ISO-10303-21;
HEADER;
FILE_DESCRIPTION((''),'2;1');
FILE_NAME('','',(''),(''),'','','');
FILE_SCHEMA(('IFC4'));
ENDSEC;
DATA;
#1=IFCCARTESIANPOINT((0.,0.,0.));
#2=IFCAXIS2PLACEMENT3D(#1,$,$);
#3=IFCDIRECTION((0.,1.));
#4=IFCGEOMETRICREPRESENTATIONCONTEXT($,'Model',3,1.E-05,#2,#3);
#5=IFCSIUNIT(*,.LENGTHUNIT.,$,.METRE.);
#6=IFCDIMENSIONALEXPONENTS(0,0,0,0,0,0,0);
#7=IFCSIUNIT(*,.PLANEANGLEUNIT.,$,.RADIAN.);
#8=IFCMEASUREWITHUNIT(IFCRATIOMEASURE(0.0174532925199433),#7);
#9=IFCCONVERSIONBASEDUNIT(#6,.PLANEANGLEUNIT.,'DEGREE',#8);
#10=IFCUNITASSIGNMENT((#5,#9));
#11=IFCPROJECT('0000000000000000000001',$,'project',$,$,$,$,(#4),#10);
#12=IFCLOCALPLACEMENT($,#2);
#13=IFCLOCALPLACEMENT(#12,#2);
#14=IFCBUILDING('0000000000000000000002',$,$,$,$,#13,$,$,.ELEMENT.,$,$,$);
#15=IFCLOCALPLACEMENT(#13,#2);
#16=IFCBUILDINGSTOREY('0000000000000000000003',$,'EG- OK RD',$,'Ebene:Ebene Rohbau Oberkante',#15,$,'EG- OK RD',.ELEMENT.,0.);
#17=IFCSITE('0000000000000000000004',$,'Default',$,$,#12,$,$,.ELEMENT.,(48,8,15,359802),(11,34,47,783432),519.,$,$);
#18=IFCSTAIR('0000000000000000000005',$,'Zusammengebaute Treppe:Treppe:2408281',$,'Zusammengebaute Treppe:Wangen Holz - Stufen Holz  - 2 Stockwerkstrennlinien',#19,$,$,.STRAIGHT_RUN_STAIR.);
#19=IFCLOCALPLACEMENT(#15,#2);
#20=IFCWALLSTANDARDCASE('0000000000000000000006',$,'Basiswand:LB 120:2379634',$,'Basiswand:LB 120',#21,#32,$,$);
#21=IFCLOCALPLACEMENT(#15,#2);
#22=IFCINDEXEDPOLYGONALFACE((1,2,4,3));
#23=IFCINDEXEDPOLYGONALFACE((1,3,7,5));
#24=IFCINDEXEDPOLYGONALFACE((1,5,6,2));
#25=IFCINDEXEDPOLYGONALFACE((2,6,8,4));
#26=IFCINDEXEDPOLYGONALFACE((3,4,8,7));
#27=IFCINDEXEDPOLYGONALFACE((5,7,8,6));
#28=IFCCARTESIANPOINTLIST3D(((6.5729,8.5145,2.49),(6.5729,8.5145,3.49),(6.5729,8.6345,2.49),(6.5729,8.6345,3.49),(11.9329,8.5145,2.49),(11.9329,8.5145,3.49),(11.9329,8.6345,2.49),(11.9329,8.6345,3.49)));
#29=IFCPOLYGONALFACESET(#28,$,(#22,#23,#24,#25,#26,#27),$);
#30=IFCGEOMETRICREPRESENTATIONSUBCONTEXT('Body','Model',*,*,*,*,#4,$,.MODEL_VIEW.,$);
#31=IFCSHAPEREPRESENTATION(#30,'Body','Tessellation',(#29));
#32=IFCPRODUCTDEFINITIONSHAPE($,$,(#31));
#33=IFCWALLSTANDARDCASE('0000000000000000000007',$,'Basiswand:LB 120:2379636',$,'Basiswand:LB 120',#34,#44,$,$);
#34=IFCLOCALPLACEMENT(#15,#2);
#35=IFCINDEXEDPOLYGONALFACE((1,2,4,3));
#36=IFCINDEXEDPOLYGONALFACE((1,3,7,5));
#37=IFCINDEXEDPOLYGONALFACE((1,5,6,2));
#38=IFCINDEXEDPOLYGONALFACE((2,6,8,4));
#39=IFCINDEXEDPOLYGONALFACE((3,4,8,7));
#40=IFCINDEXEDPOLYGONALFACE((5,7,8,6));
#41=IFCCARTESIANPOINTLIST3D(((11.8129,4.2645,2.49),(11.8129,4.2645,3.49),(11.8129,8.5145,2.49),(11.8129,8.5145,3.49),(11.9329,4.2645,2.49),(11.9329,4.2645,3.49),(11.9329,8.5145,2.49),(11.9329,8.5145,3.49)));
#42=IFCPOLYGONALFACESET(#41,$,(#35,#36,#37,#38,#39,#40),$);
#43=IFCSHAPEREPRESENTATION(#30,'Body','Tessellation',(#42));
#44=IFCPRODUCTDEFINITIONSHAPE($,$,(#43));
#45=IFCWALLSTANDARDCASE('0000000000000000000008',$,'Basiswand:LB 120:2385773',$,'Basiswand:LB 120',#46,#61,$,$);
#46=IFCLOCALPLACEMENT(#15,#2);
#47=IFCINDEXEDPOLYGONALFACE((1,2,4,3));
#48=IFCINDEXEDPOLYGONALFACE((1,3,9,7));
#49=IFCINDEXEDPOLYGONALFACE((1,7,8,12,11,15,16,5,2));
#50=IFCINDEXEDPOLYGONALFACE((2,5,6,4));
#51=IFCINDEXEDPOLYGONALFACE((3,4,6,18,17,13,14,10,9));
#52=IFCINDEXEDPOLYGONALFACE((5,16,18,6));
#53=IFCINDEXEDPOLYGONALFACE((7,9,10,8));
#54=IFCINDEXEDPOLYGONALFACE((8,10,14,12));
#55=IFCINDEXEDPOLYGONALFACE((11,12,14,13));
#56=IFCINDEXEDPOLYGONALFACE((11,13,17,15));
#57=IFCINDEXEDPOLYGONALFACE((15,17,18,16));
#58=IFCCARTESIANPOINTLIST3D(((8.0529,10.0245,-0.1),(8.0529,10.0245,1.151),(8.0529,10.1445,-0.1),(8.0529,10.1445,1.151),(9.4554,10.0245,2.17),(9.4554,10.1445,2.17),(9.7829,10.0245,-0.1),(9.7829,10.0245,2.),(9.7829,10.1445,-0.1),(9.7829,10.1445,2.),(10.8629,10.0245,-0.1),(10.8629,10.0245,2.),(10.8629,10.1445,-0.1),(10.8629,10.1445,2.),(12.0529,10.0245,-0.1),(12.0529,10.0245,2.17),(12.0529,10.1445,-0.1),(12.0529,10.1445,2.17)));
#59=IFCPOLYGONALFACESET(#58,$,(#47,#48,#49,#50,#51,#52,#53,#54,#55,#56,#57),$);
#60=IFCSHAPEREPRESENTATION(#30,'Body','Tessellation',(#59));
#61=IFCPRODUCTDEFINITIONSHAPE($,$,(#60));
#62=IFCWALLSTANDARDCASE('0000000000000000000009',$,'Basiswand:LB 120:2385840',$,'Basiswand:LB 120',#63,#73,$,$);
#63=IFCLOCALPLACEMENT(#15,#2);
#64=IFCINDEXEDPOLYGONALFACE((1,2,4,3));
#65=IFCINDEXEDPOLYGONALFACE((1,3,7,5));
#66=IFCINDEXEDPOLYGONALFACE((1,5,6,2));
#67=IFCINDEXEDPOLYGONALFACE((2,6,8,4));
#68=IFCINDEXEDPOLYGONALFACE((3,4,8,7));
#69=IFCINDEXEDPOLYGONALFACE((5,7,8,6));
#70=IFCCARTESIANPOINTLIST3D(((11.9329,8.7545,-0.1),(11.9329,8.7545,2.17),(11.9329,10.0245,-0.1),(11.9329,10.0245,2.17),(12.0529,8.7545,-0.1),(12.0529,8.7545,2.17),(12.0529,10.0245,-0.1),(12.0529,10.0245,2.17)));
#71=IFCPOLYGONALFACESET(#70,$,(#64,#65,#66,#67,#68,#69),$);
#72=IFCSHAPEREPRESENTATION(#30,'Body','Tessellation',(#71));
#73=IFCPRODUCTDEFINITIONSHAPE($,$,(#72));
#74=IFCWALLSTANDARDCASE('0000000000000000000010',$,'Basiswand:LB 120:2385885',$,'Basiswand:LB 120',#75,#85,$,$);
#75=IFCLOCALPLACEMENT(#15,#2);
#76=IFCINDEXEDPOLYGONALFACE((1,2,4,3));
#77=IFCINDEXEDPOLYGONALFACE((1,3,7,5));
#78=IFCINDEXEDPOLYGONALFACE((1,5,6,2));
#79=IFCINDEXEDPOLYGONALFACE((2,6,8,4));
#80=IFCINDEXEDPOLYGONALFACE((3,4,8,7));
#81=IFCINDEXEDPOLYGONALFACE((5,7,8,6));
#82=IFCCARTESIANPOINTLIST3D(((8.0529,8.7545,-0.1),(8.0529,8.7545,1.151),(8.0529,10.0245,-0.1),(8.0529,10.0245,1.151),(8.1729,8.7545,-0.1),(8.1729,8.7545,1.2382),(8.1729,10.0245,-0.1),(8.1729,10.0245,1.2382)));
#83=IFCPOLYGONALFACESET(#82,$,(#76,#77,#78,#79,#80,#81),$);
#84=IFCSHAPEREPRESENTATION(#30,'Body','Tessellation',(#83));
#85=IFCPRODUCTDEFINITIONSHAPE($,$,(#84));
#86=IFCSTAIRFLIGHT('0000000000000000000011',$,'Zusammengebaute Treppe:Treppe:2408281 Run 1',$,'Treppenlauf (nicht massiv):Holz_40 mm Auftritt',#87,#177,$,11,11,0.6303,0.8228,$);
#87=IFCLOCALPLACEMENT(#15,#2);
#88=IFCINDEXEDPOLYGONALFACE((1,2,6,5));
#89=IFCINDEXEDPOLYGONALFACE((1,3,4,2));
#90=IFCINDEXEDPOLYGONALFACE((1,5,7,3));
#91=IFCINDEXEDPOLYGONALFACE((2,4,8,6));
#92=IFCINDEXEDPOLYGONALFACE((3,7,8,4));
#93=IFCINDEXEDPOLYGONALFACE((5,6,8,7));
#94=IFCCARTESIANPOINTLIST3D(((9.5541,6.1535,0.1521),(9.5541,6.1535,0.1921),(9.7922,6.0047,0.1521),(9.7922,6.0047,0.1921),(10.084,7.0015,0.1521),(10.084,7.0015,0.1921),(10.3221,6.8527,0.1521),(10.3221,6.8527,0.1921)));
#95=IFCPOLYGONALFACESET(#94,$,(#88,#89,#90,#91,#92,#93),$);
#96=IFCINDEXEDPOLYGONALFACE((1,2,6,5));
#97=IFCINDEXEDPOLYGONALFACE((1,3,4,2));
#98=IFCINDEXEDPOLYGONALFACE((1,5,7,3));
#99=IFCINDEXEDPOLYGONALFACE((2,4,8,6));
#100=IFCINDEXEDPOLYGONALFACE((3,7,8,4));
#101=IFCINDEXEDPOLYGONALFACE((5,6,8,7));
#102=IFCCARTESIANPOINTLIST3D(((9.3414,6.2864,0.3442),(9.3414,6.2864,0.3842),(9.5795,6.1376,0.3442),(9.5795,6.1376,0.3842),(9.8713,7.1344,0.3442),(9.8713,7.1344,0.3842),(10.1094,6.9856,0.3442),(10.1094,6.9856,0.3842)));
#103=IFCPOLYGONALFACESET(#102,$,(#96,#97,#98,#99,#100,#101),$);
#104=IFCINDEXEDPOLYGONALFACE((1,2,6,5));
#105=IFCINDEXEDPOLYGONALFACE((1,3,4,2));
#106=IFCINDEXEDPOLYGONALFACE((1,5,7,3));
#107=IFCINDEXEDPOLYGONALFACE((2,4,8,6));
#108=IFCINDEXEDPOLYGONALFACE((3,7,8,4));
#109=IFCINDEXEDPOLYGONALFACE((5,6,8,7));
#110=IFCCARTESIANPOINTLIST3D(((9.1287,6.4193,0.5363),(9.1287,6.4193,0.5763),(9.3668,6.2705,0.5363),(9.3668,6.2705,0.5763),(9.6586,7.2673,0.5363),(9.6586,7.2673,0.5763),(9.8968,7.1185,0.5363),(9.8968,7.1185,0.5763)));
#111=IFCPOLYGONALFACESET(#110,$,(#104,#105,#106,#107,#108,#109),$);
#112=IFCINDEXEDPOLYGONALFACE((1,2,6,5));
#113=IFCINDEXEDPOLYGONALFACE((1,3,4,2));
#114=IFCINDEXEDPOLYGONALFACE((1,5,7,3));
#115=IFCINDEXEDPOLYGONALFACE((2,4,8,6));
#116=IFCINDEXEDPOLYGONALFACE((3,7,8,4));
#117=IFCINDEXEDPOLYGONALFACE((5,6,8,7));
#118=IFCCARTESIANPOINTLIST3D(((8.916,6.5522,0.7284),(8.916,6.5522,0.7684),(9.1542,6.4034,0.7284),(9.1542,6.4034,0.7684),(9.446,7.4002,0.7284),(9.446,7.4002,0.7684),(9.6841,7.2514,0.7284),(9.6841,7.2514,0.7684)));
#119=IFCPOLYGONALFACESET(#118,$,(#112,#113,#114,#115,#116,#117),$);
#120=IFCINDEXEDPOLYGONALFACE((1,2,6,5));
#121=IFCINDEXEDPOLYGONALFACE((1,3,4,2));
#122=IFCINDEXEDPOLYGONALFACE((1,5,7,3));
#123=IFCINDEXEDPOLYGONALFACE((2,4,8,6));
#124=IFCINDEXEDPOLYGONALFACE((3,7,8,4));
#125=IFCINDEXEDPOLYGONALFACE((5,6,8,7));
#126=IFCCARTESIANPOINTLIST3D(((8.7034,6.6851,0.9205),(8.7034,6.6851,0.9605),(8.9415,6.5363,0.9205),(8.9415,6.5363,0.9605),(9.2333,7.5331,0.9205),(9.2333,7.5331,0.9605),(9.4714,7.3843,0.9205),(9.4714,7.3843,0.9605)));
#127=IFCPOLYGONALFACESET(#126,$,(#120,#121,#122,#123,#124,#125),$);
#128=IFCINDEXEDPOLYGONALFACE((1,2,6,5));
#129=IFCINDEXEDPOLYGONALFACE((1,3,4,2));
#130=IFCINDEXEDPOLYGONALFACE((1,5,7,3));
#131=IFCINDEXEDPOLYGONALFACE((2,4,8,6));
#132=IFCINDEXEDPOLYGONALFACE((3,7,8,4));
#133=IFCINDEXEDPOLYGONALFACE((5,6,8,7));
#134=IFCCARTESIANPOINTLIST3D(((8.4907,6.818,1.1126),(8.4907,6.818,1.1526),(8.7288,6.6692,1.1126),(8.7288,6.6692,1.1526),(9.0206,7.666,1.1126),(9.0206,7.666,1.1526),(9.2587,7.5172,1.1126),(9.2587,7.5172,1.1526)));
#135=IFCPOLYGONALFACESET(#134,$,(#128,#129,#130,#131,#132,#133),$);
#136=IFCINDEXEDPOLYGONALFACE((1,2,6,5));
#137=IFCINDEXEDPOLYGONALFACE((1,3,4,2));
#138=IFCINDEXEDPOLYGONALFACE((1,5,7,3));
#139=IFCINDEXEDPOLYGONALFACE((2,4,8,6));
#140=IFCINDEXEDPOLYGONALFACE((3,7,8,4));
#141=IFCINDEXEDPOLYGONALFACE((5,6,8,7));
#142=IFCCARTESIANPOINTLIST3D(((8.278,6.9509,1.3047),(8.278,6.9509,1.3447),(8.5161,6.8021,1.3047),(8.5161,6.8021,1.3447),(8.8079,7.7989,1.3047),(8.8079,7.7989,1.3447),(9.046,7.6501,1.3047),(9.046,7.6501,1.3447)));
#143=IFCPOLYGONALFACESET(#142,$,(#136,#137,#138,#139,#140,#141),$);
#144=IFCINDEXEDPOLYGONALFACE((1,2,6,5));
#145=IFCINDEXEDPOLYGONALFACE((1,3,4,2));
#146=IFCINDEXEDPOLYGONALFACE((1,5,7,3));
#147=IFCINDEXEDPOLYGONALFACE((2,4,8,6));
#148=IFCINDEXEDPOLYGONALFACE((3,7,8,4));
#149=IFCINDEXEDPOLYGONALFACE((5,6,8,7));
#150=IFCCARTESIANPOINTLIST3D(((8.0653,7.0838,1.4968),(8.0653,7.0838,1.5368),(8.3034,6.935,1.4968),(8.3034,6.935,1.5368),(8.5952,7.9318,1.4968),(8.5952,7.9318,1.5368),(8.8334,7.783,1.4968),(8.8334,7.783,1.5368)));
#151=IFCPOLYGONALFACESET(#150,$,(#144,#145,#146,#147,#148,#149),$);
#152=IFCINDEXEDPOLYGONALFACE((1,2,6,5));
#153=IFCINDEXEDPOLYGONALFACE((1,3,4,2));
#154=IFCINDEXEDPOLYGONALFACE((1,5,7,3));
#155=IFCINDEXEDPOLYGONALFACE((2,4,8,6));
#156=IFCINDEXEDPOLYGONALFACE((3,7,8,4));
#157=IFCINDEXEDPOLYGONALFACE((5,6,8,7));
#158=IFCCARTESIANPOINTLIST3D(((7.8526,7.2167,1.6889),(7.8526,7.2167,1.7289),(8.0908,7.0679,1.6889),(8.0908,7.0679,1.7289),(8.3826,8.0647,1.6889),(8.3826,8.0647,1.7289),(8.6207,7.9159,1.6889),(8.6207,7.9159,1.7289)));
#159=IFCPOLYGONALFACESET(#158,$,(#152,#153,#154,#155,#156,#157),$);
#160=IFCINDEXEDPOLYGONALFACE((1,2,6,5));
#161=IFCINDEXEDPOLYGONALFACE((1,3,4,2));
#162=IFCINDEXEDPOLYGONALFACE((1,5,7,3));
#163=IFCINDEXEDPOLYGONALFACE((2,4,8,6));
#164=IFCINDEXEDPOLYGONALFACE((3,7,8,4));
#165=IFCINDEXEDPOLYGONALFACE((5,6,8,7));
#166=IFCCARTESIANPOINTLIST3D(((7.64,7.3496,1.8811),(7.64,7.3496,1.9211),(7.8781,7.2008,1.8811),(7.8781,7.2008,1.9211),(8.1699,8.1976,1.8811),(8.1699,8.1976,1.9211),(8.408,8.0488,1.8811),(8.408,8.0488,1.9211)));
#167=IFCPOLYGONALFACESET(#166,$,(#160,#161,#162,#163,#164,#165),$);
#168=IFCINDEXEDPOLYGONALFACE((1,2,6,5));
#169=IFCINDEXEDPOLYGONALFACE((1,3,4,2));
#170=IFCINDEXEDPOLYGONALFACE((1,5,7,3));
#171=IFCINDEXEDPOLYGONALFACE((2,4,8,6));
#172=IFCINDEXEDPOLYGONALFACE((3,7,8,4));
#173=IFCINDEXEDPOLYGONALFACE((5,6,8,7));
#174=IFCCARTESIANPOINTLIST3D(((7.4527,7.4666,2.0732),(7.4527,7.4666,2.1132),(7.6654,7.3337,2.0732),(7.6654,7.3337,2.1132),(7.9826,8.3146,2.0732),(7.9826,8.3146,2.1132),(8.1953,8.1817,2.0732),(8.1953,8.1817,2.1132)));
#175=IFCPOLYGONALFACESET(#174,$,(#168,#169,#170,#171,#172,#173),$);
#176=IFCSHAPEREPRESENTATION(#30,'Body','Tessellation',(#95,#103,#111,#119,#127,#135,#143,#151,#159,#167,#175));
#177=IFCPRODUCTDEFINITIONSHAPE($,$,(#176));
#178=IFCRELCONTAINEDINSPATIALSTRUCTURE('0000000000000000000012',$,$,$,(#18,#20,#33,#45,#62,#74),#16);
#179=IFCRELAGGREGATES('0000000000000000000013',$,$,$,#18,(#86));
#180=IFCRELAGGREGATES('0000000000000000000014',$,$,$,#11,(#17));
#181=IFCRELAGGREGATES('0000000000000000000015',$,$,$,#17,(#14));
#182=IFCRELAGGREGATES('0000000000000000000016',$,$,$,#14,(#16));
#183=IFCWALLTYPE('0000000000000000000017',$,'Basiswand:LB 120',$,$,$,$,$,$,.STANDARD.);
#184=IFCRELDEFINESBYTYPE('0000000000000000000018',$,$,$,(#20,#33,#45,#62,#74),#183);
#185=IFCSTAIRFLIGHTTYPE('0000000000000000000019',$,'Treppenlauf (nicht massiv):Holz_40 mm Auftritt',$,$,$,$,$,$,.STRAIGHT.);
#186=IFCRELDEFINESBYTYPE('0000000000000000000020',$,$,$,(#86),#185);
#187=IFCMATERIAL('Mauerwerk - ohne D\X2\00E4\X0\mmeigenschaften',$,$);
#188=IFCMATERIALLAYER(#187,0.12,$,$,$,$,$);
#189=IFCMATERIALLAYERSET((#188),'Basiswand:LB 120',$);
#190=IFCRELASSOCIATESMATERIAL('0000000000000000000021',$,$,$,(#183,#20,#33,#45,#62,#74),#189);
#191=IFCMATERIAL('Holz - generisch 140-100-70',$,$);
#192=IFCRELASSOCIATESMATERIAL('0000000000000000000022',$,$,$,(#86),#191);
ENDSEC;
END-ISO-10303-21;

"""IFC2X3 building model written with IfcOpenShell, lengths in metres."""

from ifc_helpers import new_model, entity, si_unit, converted_unit, direction, frame, frame_2d, origin, place, context, subcontext, project, spatial, polyline, rectangle, extrude, clip, bounded_halfspace, material, layer, layer_set, layer_usage, type_object, element, aggregate, save


model = new_model("IFC2X3")

# Units and contexts
model_context = context("Model", 3, precision=1e-05, world=origin(), true_north=direction((0.0, 1.0)))
body_context = subcontext(model_context, "Body", "Model", "MODEL_VIEW")
ifc_project = project(units=[si_unit("LENGTHUNIT", "METRE"), converted_unit("PLANEANGLEUNIT", "DEGREE", entity("IfcRatioMeasure", 0.0174532925199433), si_unit("PLANEANGLEUNIT", "RADIAN"), dimensions=[0, 0, 0, 0, 0, 0, 0])], contexts=[model_context])

# Site, building, storey
site_placement = place(None, origin())
site = spatial("IfcSite", under=ifc_project, at=site_placement, Name="Default", CompositionType="ELEMENT", RefLatitude=(48, 8, 15, 359802), RefLongitude=(11, 34, 47, 783432), RefElevation=519.0)
building_placement = place(site_placement, origin())
building = spatial("IfcBuilding", under=site, at=building_placement, CompositionType="ELEMENT")
storey_placement = place(building_placement, origin())
storey = spatial("IfcBuildingStorey", under=building, at=storey_placement, Name="EG- OK RD", ObjectType="Ebene:Ebene Rohbau Oberkante", LongName="EG- OK RD", CompositionType="ELEMENT", Elevation=0.0)

# Stair
stair_placement = place(storey_placement, origin())
stair = element("IfcStair", 1, at=stair_placement, inside=storey, Name="Zusammengebaute Treppe:Treppe:2408281", ObjectType="Zusammengebaute Treppe:Wangen Holz - Stufen Holz  - 2 Stockwerkstrennlinien", ShapeType="STRAIGHT_RUN_STAIR")
ifc_material_1 = material(Name="Holz - generisch 140-100-70")

# Walls
ifc_material_2 = material(Name="Mauerwerk - ohne Dämmeigenschaften")
ifc_layer_1 = layer(ifc_material_2, 0.12)
ifc_layer_set_1 = layer_set([ifc_layer_1], Name="Basiswand:LB 120")
wall_type_1 = type_object("IfcWallType", Name="Basiswand:LB 120", PredefinedType="STANDARD", material=ifc_layer_set_1)
ifc_layer_usage_1 = layer_usage(ifc_layer_set_1, "AXIS2", "NEGATIVE", 0.06)
wall_1_placement = place(storey_placement, frame((11.9329, 8.5745, 2.49), z_axis=(0.0, 0.0, 1.0), x_axis=(-1.0, 0.0, 0.0)))
element("IfcWallStandardCase", 2, at=wall_1_placement, inside=storey, type_object=wall_type_1, material=ifc_layer_usage_1, Name="Basiswand:LB 120:2379634", ObjectType="Basiswand:LB 120", context=body_context, shape_type="SweptSolid", body=[
    extrude(rectangle(XDim=5.36, YDim=0.12, at=frame_2d((2.68, 0.0), x_axis=(-1.0, 0.0))), origin(), (0.0, 0.0, 1.0), 1.0),
])
ifc_layer_usage_2 = layer_usage(ifc_layer_set_1, "AXIS2", "NEGATIVE", 0.06)
wall_2_placement = place(storey_placement, frame((11.8729, 4.2645, 2.49), z_axis=(0.0, 0.0, 1.0), x_axis=(0.0, 1.0, 0.0)))
element("IfcWallStandardCase", 3, at=wall_2_placement, inside=storey, type_object=wall_type_1, material=ifc_layer_usage_2, Name="Basiswand:LB 120:2379636", ObjectType="Basiswand:LB 120", context=body_context, shape_type="SweptSolid", body=[
    extrude(rectangle(XDim=4.25, YDim=0.12, at=frame_2d((2.125, 0.0), x_axis=(-1.0, 0.0))), origin(), (0.0, 0.0, 1.0), 1.0),
])

# Wall, opening
ifc_layer_usage_3 = layer_usage(ifc_layer_set_1, "AXIS2", "POSITIVE", -0.06)
wall_3_placement = place(storey_placement, frame((12.0529, 10.0845, -0.1), z_axis=(0.0, 0.0, 1.0), x_axis=(-1.0, 0.0, 0.0)))
wall_3 = element("IfcWallStandardCase", 4, at=wall_3_placement, inside=storey, type_object=wall_type_1, material=ifc_layer_usage_3, Name="Basiswand:LB 120:2385773", ObjectType="Basiswand:LB 120", context=body_context, shape_type="Clipping", body=[
    clip(clip(extrude(rectangle(XDim=4.0, YDim=0.12, at=frame_2d((2.0, 0.0), x_axis=(-1.0, 0.0))), origin(), (0.0, 0.0, 1.0), 2.27), bounded_halfspace(frame((0.0, 0.06, 2.27), z_axis=(0.0, 0.0, -1.0), x_axis=(0.0, 1.0, 0.0)), True, frame((0.0, 0.06, 2.27)), polyline([(0.0, 0.0), (0.0, -0.12), (2.5975, -0.12), (2.5975, 0.0), (0.12, 0.0), (0.0, 0.0)]))), bounded_halfspace(frame((4.0, -0.06, 1.251), z_axis=(-0.587785, 0.0, -0.809017), x_axis=(0.0, 1.0, 0.0)), True, frame((4.0, -0.06, 1.251)), polyline([(0.0, 0.0), (0.0, 0.12), (-0.12, 0.12), (-1.4025, 0.12), (-1.4025, 0.0), (0.0, 0.0)]))),
])
opening_1_placement = place(wall_3_placement, frame((1.19, -0.06, 0.0)))
element("IfcOpeningElement", 5, at=opening_1_placement, cuts=wall_3, ObjectType="Opening", context=body_context, shape_type="SweptSolid", body=[
    extrude(rectangle(XDim=2.1, YDim=1.08, at=frame_2d((1.05, 0.54), x_axis=(-1.0, 0.0))), frame((0.0, 0.0, 0.0), z_axis=(0.0, 1.0, 0.0), x_axis=(0.0, 0.0, 1.0)), (0.0, 0.0, 1.0), 0.12),
])

# Walls
ifc_layer_usage_4 = layer_usage(ifc_layer_set_1, "AXIS2", "POSITIVE", -0.06)
wall_4_placement = place(storey_placement, frame((11.9929, 8.7545, -0.1), z_axis=(0.0, 0.0, 1.0), x_axis=(0.0, 1.0, 0.0)))
element("IfcWallStandardCase", 6, at=wall_4_placement, inside=storey, type_object=wall_type_1, material=ifc_layer_usage_4, Name="Basiswand:LB 120:2385840", ObjectType="Basiswand:LB 120", context=body_context, shape_type="Clipping", body=[
    clip(extrude(rectangle(XDim=1.27, YDim=0.12, at=frame_2d((0.635, 0.0), x_axis=(-1.0, 0.0))), origin(), (0.0, 0.0, 1.0), 2.27), bounded_halfspace(frame((0.0, -0.06, 2.27), z_axis=(0.0, 0.0, -1.0), x_axis=(-1.0, 0.0, 0.0)), True, frame((0.0, -0.06, 2.27)), polyline([(0.0, 0.0), (1.27, 0.0), (1.27, 0.12), (0.0, 0.12), (0.0, 0.0)]))),
])
ifc_layer_usage_5 = layer_usage(ifc_layer_set_1, "AXIS2", "NEGATIVE", 0.06)
wall_5_placement = place(storey_placement, frame((8.1129, 8.7545, -0.1), z_axis=(0.0, 0.0, 1.0), x_axis=(0.0, 1.0, 0.0)))
element("IfcWallStandardCase", 7, at=wall_5_placement, inside=storey, type_object=wall_type_1, material=ifc_layer_usage_5, Name="Basiswand:LB 120:2385885", ObjectType="Basiswand:LB 120", context=body_context, shape_type="Clipping", body=[
    clip(extrude(rectangle(XDim=1.27, YDim=0.12, at=frame_2d((0.635, 0.0), x_axis=(-1.0, 0.0))), origin(), (0.0, 0.0, 1.0), 1.3382), bounded_halfspace(frame((0.0, -0.06, 1.3382), z_axis=(0.0, -0.587785, -0.809017), x_axis=(-1.0, 0.0, 0.0)), True, frame((0.0, -0.06, 1.3382)), polyline([(0.0, 0.0), (1.27, 0.0), (1.27, 0.12), (0.0, 0.12), (0.0, 0.0)]))),
])

# Stair flight
stair_flight_type = type_object("IfcStairFlightType", Name="Treppenlauf (nicht massiv):Holz_40 mm Auftritt", PredefinedType="STRAIGHT")
stair_flight_placement = place(stair_placement, origin())
stair_flight = element("IfcStairFlight", 8, at=stair_flight_placement, type_object=stair_flight_type, material=ifc_material_1, Name="Zusammengebaute Treppe:Treppe:2408281 Run 1", ObjectType="Treppenlauf (nicht massiv):Holz_40 mm Auftritt", NumberOfRiser=11, NumberOfTreads=11, RiserHeight=0.6303, TreadLength=0.8228, context=body_context, shape_type="SweptSolid", body=[
    extrude(rectangle(XDim=0.2808, YDim=1.0, at=frame_2d((0.0, 0.0), x_axis=(1.0, 0.0))), frame((9.9381, 6.5031, 0.1521), z_axis=(0.0, 0.0, 1.0), x_axis=(0.848048, -0.529919, 0.0)), (0.0, 0.0, 1.0), 0.04),
    extrude(rectangle(XDim=0.2808, YDim=1.0, at=frame_2d((0.0, 0.0), x_axis=(1.0, 0.0))), frame((9.7254, 6.636, 0.3442), z_axis=(0.0, 0.0, 1.0), x_axis=(0.848048, -0.529919, 0.0)), (0.0, 0.0, 1.0), 0.04),
    extrude(rectangle(XDim=0.2808, YDim=1.0, at=frame_2d((0.0, 0.0), x_axis=(1.0, 0.0))), frame((9.5127, 6.7689, 0.5363), z_axis=(0.0, 0.0, 1.0), x_axis=(0.848048, -0.529919, 0.0)), (0.0, 0.0, 1.0), 0.04),
    extrude(rectangle(XDim=0.2808, YDim=1.0, at=frame_2d((0.0, 0.0), x_axis=(1.0, 0.0))), frame((9.3001, 6.9018, 0.7284), z_axis=(0.0, 0.0, 1.0), x_axis=(0.848048, -0.529919, 0.0)), (0.0, 0.0, 1.0), 0.04),
    extrude(rectangle(XDim=0.2808, YDim=1.0, at=frame_2d((0.0, 0.0), x_axis=(1.0, 0.0))), frame((9.0874, 7.0347, 0.9205), z_axis=(0.0, 0.0, 1.0), x_axis=(0.848048, -0.529919, 0.0)), (0.0, 0.0, 1.0), 0.04),
    extrude(rectangle(XDim=0.2808, YDim=1.0, at=frame_2d((0.0, 0.0), x_axis=(1.0, 0.0))), frame((8.8747, 7.1676, 1.1126), z_axis=(0.0, 0.0, 1.0), x_axis=(0.848048, -0.529919, 0.0)), (0.0, 0.0, 1.0), 0.04),
    extrude(rectangle(XDim=0.2808, YDim=1.0, at=frame_2d((0.0, 0.0), x_axis=(1.0, 0.0))), frame((8.662, 7.3005, 1.3047), z_axis=(0.0, 0.0, 1.0), x_axis=(0.848048, -0.529919, 0.0)), (0.0, 0.0, 1.0), 0.04),
    extrude(rectangle(XDim=0.2808, YDim=1.0, at=frame_2d((0.0, 0.0), x_axis=(1.0, 0.0))), frame((8.4493, 7.4334, 1.4968), z_axis=(0.0, 0.0, 1.0), x_axis=(0.848048, -0.529919, 0.0)), (0.0, 0.0, 1.0), 0.04),
    extrude(rectangle(XDim=0.2808, YDim=1.0, at=frame_2d((0.0, 0.0), x_axis=(1.0, 0.0))), frame((8.2367, 7.5663, 1.6889), z_axis=(0.0, 0.0, 1.0), x_axis=(0.848048, -0.529919, 0.0)), (0.0, 0.0, 1.0), 0.04),
    extrude(rectangle(XDim=0.2808, YDim=1.0, at=frame_2d((0.0, 0.0), x_axis=(1.0, 0.0))), frame((8.024, 7.6992, 1.8811), z_axis=(0.0, 0.0, 1.0), x_axis=(0.848048, -0.529919, 0.0)), (0.0, 0.0, 1.0), 0.04),
    extrude(rectangle(XDim=0.2508, YDim=1.0, at=frame_2d((0.0, 0.0), x_axis=(1.0, 0.0))), frame((7.824, 7.8241, 2.0732), z_axis=(0.0, 0.0, 1.0), x_axis=(0.848048, -0.529919, 0.0)), (0.0, 0.0, 1.0), 0.04),
])
aggregate(stair, [stair_flight])

save(model, "model.ifc")
